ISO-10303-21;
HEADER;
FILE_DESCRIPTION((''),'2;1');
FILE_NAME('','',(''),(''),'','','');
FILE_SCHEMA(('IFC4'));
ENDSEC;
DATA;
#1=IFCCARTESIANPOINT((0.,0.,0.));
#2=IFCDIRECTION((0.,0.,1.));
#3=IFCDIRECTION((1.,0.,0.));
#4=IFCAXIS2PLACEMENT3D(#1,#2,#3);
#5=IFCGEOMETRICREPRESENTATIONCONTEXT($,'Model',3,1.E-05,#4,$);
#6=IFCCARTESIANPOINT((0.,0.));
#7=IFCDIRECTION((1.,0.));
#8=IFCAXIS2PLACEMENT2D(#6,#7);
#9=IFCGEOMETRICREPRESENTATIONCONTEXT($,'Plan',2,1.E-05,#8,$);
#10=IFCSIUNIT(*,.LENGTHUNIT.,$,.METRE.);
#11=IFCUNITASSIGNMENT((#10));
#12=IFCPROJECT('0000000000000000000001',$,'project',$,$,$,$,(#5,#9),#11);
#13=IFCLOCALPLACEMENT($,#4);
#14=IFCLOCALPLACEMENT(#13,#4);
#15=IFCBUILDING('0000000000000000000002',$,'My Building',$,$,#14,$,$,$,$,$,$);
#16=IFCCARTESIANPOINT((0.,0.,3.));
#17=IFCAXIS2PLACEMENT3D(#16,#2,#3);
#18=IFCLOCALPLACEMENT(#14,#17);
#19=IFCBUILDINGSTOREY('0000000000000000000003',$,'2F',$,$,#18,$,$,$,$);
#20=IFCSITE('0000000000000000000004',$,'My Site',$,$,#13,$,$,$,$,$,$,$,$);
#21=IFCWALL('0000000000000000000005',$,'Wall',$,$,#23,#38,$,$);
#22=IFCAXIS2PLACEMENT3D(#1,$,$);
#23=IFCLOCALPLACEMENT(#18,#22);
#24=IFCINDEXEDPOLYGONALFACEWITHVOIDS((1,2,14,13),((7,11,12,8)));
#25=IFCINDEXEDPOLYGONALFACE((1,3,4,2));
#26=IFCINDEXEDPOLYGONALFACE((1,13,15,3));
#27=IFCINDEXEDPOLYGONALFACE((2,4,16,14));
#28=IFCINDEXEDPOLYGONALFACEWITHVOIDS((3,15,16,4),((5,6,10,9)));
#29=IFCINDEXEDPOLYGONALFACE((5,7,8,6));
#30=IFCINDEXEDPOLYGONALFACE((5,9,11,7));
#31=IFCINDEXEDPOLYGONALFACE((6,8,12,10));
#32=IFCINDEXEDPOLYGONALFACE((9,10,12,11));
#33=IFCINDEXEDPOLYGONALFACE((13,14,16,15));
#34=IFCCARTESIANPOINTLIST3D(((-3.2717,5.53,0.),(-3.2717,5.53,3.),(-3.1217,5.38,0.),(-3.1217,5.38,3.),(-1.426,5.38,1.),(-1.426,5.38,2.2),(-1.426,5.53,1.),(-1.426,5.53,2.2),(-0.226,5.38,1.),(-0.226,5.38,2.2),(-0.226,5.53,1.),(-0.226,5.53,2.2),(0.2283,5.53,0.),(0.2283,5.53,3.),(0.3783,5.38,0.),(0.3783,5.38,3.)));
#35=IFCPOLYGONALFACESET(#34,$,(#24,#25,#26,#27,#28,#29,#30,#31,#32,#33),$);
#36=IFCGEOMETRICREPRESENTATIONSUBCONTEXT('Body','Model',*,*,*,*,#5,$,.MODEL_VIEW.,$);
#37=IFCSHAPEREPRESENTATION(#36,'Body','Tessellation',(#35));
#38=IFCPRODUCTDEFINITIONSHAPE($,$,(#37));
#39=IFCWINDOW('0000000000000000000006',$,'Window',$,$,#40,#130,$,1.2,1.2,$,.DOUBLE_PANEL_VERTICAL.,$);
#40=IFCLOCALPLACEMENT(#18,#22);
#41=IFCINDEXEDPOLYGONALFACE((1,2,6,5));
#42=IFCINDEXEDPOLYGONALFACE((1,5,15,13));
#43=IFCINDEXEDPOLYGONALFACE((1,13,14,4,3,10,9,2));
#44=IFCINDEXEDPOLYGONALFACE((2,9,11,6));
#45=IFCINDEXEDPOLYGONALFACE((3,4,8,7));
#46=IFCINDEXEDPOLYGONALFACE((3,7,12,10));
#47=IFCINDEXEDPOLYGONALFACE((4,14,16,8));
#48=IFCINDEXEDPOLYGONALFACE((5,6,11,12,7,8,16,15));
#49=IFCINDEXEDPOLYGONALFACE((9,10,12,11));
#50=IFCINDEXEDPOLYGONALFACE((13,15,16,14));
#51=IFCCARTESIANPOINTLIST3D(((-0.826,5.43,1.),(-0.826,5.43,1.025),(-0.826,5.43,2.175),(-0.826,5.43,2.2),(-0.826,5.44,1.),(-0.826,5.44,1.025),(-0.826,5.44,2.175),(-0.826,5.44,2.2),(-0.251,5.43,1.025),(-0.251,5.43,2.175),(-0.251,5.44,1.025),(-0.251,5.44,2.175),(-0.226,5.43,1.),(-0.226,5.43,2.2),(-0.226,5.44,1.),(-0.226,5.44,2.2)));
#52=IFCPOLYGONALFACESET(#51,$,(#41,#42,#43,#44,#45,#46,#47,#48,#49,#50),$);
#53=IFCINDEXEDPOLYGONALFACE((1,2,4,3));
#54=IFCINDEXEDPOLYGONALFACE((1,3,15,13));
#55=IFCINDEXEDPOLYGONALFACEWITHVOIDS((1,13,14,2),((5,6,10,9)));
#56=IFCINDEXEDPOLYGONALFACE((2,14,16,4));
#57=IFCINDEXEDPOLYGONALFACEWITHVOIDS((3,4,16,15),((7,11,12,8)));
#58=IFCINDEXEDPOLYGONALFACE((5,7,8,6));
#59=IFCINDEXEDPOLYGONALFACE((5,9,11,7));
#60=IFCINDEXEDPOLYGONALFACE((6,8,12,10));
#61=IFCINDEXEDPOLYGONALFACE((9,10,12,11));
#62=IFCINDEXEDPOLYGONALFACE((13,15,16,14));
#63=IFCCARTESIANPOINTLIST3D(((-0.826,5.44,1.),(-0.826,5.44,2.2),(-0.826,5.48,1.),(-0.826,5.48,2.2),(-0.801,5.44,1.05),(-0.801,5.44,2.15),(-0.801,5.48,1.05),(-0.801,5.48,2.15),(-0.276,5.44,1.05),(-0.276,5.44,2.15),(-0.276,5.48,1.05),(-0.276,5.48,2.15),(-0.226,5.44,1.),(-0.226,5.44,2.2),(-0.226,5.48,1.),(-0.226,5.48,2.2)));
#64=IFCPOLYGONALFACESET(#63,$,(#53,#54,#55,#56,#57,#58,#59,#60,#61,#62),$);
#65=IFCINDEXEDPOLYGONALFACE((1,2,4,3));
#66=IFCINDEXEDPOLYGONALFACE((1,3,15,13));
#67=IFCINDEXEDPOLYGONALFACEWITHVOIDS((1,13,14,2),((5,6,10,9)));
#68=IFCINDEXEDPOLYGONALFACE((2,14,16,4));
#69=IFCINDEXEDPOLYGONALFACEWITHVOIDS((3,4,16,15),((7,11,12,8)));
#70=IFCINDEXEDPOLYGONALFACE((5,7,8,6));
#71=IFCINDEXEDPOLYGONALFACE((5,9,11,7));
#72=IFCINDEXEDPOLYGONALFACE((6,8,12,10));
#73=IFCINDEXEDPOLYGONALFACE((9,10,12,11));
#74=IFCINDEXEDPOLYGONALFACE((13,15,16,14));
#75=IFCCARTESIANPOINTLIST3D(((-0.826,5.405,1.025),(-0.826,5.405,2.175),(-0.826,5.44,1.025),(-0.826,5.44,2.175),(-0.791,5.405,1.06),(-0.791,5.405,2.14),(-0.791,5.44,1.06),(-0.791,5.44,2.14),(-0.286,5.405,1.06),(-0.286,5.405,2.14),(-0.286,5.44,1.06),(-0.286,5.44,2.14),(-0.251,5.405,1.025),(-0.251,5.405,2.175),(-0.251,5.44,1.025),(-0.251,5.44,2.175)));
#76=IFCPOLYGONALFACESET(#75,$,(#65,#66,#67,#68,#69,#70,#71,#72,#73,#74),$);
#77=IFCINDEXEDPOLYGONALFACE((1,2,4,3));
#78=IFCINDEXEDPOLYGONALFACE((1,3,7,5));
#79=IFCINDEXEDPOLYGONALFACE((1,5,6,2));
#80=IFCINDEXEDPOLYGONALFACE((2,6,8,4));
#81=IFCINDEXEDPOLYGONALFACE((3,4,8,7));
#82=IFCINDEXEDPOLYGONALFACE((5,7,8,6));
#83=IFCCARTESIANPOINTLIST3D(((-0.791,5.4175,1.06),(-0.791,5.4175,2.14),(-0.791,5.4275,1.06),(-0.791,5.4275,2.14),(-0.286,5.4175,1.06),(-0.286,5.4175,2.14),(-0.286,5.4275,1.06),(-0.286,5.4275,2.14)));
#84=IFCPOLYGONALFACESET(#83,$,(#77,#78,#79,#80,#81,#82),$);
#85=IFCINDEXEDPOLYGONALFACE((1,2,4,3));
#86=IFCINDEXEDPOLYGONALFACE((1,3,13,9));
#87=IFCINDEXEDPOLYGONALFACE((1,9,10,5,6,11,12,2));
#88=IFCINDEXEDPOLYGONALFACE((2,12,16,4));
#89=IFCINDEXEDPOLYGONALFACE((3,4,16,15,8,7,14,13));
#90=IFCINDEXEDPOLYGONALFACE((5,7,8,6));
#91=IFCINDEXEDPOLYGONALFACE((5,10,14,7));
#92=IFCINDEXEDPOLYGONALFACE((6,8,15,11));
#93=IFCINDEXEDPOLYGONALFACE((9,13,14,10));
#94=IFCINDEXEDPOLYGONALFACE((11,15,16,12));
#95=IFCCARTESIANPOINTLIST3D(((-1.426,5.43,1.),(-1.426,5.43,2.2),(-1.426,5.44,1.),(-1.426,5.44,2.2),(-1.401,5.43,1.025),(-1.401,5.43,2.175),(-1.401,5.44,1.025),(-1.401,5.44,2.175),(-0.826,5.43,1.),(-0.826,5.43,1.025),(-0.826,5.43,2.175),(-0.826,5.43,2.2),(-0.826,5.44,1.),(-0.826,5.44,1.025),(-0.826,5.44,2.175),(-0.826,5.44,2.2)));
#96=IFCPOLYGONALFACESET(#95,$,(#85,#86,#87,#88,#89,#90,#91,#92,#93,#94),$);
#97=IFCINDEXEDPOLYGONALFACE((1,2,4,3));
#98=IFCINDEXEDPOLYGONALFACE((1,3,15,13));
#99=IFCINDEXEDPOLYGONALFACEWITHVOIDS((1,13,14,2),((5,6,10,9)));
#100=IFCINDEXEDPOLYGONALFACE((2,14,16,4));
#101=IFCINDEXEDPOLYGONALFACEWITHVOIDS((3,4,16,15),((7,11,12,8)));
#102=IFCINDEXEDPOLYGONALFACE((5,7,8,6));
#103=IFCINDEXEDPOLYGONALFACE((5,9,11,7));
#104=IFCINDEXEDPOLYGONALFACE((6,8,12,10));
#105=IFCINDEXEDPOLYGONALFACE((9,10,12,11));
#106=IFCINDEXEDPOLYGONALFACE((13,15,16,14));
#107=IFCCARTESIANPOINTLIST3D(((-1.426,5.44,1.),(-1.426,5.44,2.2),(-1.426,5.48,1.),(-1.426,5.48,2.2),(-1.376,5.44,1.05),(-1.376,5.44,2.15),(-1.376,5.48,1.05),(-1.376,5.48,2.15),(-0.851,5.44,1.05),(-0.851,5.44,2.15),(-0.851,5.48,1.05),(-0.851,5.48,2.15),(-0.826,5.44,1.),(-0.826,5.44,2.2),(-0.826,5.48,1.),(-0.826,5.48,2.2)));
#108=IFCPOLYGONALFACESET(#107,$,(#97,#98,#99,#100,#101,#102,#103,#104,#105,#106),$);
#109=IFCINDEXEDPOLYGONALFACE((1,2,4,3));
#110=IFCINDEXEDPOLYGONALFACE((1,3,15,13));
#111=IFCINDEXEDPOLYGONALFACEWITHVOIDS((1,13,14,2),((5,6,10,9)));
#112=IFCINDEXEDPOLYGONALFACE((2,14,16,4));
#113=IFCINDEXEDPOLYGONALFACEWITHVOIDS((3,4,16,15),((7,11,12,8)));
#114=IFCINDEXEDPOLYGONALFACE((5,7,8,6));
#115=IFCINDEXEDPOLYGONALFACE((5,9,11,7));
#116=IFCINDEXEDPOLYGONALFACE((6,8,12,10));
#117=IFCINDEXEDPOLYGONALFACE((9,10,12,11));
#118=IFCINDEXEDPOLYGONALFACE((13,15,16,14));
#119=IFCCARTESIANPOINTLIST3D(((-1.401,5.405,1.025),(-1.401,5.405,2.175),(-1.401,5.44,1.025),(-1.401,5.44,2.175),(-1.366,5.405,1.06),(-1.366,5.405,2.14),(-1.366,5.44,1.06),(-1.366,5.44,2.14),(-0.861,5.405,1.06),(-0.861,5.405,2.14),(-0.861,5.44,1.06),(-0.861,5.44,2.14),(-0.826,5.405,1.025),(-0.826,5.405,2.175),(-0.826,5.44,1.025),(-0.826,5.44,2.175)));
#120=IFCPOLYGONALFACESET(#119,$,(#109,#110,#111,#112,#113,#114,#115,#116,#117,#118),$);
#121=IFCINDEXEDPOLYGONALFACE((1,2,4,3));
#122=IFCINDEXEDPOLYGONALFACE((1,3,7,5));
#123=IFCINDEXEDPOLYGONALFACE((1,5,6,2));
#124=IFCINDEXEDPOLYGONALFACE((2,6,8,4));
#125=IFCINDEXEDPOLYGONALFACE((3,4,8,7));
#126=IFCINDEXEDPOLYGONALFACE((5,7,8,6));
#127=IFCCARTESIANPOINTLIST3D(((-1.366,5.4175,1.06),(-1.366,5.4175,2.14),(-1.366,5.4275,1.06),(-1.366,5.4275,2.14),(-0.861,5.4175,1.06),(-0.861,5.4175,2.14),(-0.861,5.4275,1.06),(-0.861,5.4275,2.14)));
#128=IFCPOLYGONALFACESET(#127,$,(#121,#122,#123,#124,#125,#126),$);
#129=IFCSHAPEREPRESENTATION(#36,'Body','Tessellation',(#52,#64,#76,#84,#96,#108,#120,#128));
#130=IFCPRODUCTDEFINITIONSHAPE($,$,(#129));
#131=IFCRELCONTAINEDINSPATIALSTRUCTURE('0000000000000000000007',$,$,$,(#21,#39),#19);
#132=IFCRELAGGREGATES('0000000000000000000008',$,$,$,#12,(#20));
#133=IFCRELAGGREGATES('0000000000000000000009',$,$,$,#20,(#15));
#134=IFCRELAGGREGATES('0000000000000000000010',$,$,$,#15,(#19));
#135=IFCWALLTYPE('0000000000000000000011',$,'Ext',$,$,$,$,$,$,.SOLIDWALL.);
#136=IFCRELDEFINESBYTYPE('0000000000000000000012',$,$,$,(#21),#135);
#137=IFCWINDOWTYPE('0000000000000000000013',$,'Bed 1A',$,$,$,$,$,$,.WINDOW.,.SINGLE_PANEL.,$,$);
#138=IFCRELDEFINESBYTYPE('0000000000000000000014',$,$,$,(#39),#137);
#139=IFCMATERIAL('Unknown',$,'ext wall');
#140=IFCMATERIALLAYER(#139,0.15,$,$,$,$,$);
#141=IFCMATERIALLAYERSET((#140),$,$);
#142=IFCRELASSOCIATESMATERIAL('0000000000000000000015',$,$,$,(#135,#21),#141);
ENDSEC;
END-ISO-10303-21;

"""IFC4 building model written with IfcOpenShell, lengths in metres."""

from ifc_helpers import new_model, entity, si_unit, frame, origin_with_axes, origin_2d_with_axis, place, context, subcontext, project, spatial, line, indexed_curve, outline, extrude, shape, source, transform, mapped, material, layer, layer_set, layer_usage, type_object, type_shapes, element, fill, save


model = new_model("IFC4")

# Units and contexts
model_context = context("Model", 3, precision=1e-05, world=origin_with_axes())
plan_context = context("Plan", 2, precision=1e-05, world=origin_2d_with_axis())
body_context_1 = subcontext(model_context, "Body", "Model", "MODEL_VIEW")
body_context_2 = subcontext(plan_context, "Body", "Plan", "PLAN_VIEW")
ifc_project = project(units=[si_unit("LENGTHUNIT", "METRE")], contexts=[model_context, plan_context])

# Site, building, storey
site_placement = place(None, origin_with_axes())
site = spatial("IfcSite", under=ifc_project, at=site_placement, Name="My Site")
building_placement = place(site_placement, origin_with_axes())
building = spatial("IfcBuilding", under=site, at=building_placement, Name="My Building")
storey_placement = place(building_placement, frame((0.0, 0.0, 3.0), z_axis=(0.0, 0.0, 1.0), x_axis=(1.0, 0.0, 0.0)))
storey = spatial("IfcBuildingStorey", under=building, at=storey_placement, Name="2F")

# Shared definitions
ifc_material = material(Name="Unknown", Category="ext wall")

# Shared definitions
ifc_layer_1 = layer(ifc_material, 0.15)
ifc_layer_set_1 = layer_set([ifc_layer_1])
wall_type_1 = type_object("IfcWallType", Name="Ext", PredefinedType="SOLIDWALL", material=ifc_layer_set_1)

# Wall, opening, window
ifc_layer_usage_1 = layer_usage(ifc_layer_set_1, "AXIS2", "POSITIVE", 0.0)
wall_1_placement = place(storey_placement, frame((0.2283, 5.53, 0.0), z_axis=(0.0, 0.0, 1.0), x_axis=(-1.0, 0.0, 0.0)))
wall_1 = element("IfcWall", 1, at=wall_1_placement, inside=storey, type_object=wall_type_1, material=ifc_layer_usage_1, Name="Wall", context=body_context_1, shape_type="SweptSolid", body=[
    extrude(outline(indexed_curve([(0.0, 0.0), (-0.15, 0.15), (3.35, 0.15), (3.5, 0.0)], segments=[line(1, 2, 3, 4, 1)])), origin_with_axes(), (0.0, 0.0, 1.0), 3.0),
])
shared_shape_1 = source(origin_with_axes(), body_context_1, "Body", "SweptSolid", [
    extrude(outline(indexed_curve([(0.0, 0.0), (1.2, 0.0), (1.2, 1.2), (0.0, 1.2)], segments=[line(1, 2, 3, 4, 1)])), frame((0.0, -0.6, 0.0), z_axis=(0.0, -1.0, 0.0), x_axis=(1.0, 0.0, 0.0)), (0.0, 0.0, -1.0), 1.2),
])
opening_1_placement = place(wall_1_placement, frame((0.4544, 0.0, 1.0), z_axis=(0.0, 0.0, 1.0), x_axis=(1.0, 0.0, 0.0)))
opening_1 = element("IfcOpeningElement", 2, at=opening_1_placement, cuts=wall_1, PredefinedType="OPENING", context=body_context_1, shape_type="MappedRepresentation", body=[
    mapped(shared_shape_1, transform((0.0, 0.0, 0.0), x_axis=(1.0, 0.0, 0.0), y_axis=(0.0, 1.0, 0.0), z_axis=(0.0, 0.0, 1.0), scale=1.0)),
])
window_type_1 = type_object("IfcWindowType", Name="Bed 1A", PartitioningType="SINGLE_PANEL", PredefinedType="WINDOW")
shared_shape_2 = source(origin_with_axes(), body_context_1, "Body", "SweptSolid", [
    extrude(outline(indexed_curve([(0.6, 0.0), (0.0, 0.0), (0.0, 1.2), (0.6, 1.2), (0.6, 1.175), (0.025, 1.175), (0.025, 0.025), (0.6, 0.025)], segments=[line(1, 2, 3, 4, 5, 6, 7, 8, 1)])), frame((0.0, 0.09, 0.0), z_axis=(0.0, -1.0, 0.0), x_axis=(1.0, 0.0, 0.0)), (0.0, 0.0, -1.0), 0.01),
    extrude(outline(indexed_curve([(0.0, 0.0), (0.6, 0.0), (0.6, 1.2), (0.0, 1.2)], segments=[line(1, 2, 3, 4, 1)]), holes=[indexed_curve([(0.05, 0.05), (0.575, 0.05), (0.575, 1.15), (0.05, 1.15)], segments=[line(1, 2, 3, 4, 1)])]), frame((0.0, 0.05, 0.0), z_axis=(0.0, -1.0, 0.0), x_axis=(1.0, 0.0, 0.0)), (0.0, 0.0, -1.0), 0.04),
    extrude(outline(indexed_curve([(0.0, 0.0), (0.575, 0.0), (0.575, 1.15), (0.0, 1.15)], segments=[line(1, 2, 3, 4, 1)]), holes=[indexed_curve([(0.035, 0.035), (0.54, 0.035), (0.54, 1.115), (0.035, 1.115)], segments=[line(1, 2, 3, 4, 1)])]), frame((0.025, 0.09, 0.025), z_axis=(0.0, -1.0, 0.0), x_axis=(1.0, 0.0, 0.0)), (0.0, 0.0, -1.0), 0.035),
    extrude(outline(indexed_curve([(0.035, 0.035), (0.54, 0.035), (0.54, 1.115), (0.035, 1.115)], segments=[line(1, 2, 3, 4, 1)])), frame((0.025, 0.1025, 0.025), z_axis=(0.0, -1.0, 0.0), x_axis=(1.0, 0.0, 0.0)), (0.0, 0.0, -1.0), 0.01),
    extrude(outline(indexed_curve([(0.0, 1.2), (0.6, 1.2), (0.6, 0.0), (0.0, 0.0), (0.0, 0.025), (0.575, 0.025), (0.575, 1.175), (0.0, 1.175)], segments=[line(1, 2, 3, 4, 5, 6, 7, 8, 1)])), frame((0.6, 0.09, 0.0), z_axis=(0.0, -1.0, 0.0), x_axis=(1.0, 0.0, 0.0)), (0.0, 0.0, -1.0), 0.01),
    extrude(outline(indexed_curve([(0.0, 0.0), (0.6, 0.0), (0.6, 1.2), (0.0, 1.2)], segments=[line(1, 2, 3, 4, 1)]), holes=[indexed_curve([(0.025, 0.05), (0.55, 0.05), (0.55, 1.15), (0.025, 1.15)], segments=[line(1, 2, 3, 4, 1)])]), frame((0.6, 0.05, 0.0), z_axis=(0.0, -1.0, 0.0), x_axis=(1.0, 0.0, 0.0)), (0.0, 0.0, -1.0), 0.04),
    extrude(outline(indexed_curve([(0.0, 0.0), (0.575, 0.0), (0.575, 1.15), (0.0, 1.15)], segments=[line(1, 2, 3, 4, 1)]), holes=[indexed_curve([(0.035, 0.035), (0.54, 0.035), (0.54, 1.115), (0.035, 1.115)], segments=[line(1, 2, 3, 4, 1)])]), frame((0.6, 0.09, 0.025), z_axis=(0.0, -1.0, 0.0), x_axis=(1.0, 0.0, 0.0)), (0.0, 0.0, -1.0), 0.035),
    extrude(outline(indexed_curve([(0.035, 0.035), (0.54, 0.035), (0.54, 1.115), (0.035, 1.115)], segments=[line(1, 2, 3, 4, 1)])), frame((0.6, 0.1025, 0.025), z_axis=(0.0, -1.0, 0.0), x_axis=(1.0, 0.0, 0.0)), (0.0, 0.0, -1.0), 0.01),
])
shared_shape_3 = source(origin_with_axes(), body_context_2, "Body", "Curve2D", [
    entity("IfcIndexedPolyCurve", entity("IfcCartesianPointList2D", [[0.05, 0.05], [0.575, 0.05]])),
    entity("IfcIndexedPolyCurve", entity("IfcCartesianPointList2D", [[0.0, 0.1], [0.025, 0.1], [0.025, 0.09], [0.05, 0.09], [0.05, 0.05], [0.0, 0.05]]), [entity("IfcLineIndex", [1, 2, 3, 4, 5, 6, 1])]),
    entity("IfcIndexedPolyCurve", entity("IfcCartesianPointList2D", [[0.6, 0.1], [0.6, 0.1], [0.6, 0.09], [0.575, 0.09], [0.575, 0.05], [0.6, 0.05]])),
    entity("IfcIndexedPolyCurve", entity("IfcCartesianPointList2D", [[0.025, 0.09], [0.06, 0.09], [0.06, 0.125], [0.025, 0.125]]), [entity("IfcLineIndex", [1, 2, 3, 4, 1])]),
    entity("IfcIndexedPolyCurve", entity("IfcCartesianPointList2D", [[0.6, 0.09], [0.565, 0.09], [0.565, 0.125], [0.6, 0.125]]), [entity("IfcLineIndex", [1, 2, 3, 4, 1])]),
    entity("IfcIndexedPolyCurve", entity("IfcCartesianPointList2D", [[0.06, 0.09], [0.565, 0.09]])),
    entity("IfcIndexedPolyCurve", entity("IfcCartesianPointList2D", [[0.06, 0.125], [0.565, 0.125]])),
    entity("IfcIndexedPolyCurve", entity("IfcCartesianPointList2D", [[0.06, 0.1075], [0.565, 0.1075]])),
    entity("IfcIndexedPolyCurve", entity("IfcCartesianPointList2D", [[0.625, 0.05], [1.15, 0.05]])),
    entity("IfcIndexedPolyCurve", entity("IfcCartesianPointList2D", [[0.6, 0.1], [0.6, 0.1], [0.6, 0.09], [0.625, 0.09], [0.625, 0.05], [0.6, 0.05]])),
    entity("IfcIndexedPolyCurve", entity("IfcCartesianPointList2D", [[1.2, 0.1], [1.175, 0.1], [1.175, 0.09], [1.15, 0.09], [1.15, 0.05], [1.2, 0.05]]), [entity("IfcLineIndex", [1, 2, 3, 4, 5, 6, 1])]),
    entity("IfcIndexedPolyCurve", entity("IfcCartesianPointList2D", [[0.6, 0.09], [0.635, 0.09], [0.635, 0.125], [0.6, 0.125]]), [entity("IfcLineIndex", [1, 2, 3, 4, 1])]),
    entity("IfcIndexedPolyCurve", entity("IfcCartesianPointList2D", [[1.175, 0.09], [1.14, 0.09], [1.14, 0.125], [1.175, 0.125]]), [entity("IfcLineIndex", [1, 2, 3, 4, 1])]),
    entity("IfcIndexedPolyCurve", entity("IfcCartesianPointList2D", [[0.635, 0.09], [1.14, 0.09]])),
    entity("IfcIndexedPolyCurve", entity("IfcCartesianPointList2D", [[0.635, 0.125], [1.14, 0.125]])),
    entity("IfcIndexedPolyCurve", entity("IfcCartesianPointList2D", [[0.635, 0.1075], [1.14, 0.1075]])),
])
type_shapes(window_type_1, [shared_shape_2, shared_shape_3])
window_1_placement = place(opening_1_placement, frame((0.0, 0.0, 0.0), z_axis=(0.0, 0.0, 1.0), x_axis=(1.0, 0.0, 0.0)))
window_1 = element("IfcWindow", 3, at=window_1_placement, inside=storey, type_object=window_type_1, Name="Window", OverallHeight=1.2, OverallWidth=1.2, PartitioningType="DOUBLE_PANEL_VERTICAL", shapes=[
    shape(body_context_1, "Body", "MappedRepresentation", [mapped(shared_shape_2, transform((0.0, 0.0, 0.0), x_axis=(1.0, 0.0, 0.0), y_axis=(0.0, 1.0, 0.0), z_axis=(0.0, 0.0, 1.0), scale=1.0))]),
    shape(body_context_2, "Body", "MappedRepresentation", [mapped(shared_shape_3, transform((0.0, 0.0, 0.0), x_axis=(1.0, 0.0, 0.0), y_axis=(0.0, 1.0, 0.0), z_axis=(0.0, 0.0, 1.0), scale=1.0))]),
])
fill(opening_1, window_1)

save(model, "model.ifc")
